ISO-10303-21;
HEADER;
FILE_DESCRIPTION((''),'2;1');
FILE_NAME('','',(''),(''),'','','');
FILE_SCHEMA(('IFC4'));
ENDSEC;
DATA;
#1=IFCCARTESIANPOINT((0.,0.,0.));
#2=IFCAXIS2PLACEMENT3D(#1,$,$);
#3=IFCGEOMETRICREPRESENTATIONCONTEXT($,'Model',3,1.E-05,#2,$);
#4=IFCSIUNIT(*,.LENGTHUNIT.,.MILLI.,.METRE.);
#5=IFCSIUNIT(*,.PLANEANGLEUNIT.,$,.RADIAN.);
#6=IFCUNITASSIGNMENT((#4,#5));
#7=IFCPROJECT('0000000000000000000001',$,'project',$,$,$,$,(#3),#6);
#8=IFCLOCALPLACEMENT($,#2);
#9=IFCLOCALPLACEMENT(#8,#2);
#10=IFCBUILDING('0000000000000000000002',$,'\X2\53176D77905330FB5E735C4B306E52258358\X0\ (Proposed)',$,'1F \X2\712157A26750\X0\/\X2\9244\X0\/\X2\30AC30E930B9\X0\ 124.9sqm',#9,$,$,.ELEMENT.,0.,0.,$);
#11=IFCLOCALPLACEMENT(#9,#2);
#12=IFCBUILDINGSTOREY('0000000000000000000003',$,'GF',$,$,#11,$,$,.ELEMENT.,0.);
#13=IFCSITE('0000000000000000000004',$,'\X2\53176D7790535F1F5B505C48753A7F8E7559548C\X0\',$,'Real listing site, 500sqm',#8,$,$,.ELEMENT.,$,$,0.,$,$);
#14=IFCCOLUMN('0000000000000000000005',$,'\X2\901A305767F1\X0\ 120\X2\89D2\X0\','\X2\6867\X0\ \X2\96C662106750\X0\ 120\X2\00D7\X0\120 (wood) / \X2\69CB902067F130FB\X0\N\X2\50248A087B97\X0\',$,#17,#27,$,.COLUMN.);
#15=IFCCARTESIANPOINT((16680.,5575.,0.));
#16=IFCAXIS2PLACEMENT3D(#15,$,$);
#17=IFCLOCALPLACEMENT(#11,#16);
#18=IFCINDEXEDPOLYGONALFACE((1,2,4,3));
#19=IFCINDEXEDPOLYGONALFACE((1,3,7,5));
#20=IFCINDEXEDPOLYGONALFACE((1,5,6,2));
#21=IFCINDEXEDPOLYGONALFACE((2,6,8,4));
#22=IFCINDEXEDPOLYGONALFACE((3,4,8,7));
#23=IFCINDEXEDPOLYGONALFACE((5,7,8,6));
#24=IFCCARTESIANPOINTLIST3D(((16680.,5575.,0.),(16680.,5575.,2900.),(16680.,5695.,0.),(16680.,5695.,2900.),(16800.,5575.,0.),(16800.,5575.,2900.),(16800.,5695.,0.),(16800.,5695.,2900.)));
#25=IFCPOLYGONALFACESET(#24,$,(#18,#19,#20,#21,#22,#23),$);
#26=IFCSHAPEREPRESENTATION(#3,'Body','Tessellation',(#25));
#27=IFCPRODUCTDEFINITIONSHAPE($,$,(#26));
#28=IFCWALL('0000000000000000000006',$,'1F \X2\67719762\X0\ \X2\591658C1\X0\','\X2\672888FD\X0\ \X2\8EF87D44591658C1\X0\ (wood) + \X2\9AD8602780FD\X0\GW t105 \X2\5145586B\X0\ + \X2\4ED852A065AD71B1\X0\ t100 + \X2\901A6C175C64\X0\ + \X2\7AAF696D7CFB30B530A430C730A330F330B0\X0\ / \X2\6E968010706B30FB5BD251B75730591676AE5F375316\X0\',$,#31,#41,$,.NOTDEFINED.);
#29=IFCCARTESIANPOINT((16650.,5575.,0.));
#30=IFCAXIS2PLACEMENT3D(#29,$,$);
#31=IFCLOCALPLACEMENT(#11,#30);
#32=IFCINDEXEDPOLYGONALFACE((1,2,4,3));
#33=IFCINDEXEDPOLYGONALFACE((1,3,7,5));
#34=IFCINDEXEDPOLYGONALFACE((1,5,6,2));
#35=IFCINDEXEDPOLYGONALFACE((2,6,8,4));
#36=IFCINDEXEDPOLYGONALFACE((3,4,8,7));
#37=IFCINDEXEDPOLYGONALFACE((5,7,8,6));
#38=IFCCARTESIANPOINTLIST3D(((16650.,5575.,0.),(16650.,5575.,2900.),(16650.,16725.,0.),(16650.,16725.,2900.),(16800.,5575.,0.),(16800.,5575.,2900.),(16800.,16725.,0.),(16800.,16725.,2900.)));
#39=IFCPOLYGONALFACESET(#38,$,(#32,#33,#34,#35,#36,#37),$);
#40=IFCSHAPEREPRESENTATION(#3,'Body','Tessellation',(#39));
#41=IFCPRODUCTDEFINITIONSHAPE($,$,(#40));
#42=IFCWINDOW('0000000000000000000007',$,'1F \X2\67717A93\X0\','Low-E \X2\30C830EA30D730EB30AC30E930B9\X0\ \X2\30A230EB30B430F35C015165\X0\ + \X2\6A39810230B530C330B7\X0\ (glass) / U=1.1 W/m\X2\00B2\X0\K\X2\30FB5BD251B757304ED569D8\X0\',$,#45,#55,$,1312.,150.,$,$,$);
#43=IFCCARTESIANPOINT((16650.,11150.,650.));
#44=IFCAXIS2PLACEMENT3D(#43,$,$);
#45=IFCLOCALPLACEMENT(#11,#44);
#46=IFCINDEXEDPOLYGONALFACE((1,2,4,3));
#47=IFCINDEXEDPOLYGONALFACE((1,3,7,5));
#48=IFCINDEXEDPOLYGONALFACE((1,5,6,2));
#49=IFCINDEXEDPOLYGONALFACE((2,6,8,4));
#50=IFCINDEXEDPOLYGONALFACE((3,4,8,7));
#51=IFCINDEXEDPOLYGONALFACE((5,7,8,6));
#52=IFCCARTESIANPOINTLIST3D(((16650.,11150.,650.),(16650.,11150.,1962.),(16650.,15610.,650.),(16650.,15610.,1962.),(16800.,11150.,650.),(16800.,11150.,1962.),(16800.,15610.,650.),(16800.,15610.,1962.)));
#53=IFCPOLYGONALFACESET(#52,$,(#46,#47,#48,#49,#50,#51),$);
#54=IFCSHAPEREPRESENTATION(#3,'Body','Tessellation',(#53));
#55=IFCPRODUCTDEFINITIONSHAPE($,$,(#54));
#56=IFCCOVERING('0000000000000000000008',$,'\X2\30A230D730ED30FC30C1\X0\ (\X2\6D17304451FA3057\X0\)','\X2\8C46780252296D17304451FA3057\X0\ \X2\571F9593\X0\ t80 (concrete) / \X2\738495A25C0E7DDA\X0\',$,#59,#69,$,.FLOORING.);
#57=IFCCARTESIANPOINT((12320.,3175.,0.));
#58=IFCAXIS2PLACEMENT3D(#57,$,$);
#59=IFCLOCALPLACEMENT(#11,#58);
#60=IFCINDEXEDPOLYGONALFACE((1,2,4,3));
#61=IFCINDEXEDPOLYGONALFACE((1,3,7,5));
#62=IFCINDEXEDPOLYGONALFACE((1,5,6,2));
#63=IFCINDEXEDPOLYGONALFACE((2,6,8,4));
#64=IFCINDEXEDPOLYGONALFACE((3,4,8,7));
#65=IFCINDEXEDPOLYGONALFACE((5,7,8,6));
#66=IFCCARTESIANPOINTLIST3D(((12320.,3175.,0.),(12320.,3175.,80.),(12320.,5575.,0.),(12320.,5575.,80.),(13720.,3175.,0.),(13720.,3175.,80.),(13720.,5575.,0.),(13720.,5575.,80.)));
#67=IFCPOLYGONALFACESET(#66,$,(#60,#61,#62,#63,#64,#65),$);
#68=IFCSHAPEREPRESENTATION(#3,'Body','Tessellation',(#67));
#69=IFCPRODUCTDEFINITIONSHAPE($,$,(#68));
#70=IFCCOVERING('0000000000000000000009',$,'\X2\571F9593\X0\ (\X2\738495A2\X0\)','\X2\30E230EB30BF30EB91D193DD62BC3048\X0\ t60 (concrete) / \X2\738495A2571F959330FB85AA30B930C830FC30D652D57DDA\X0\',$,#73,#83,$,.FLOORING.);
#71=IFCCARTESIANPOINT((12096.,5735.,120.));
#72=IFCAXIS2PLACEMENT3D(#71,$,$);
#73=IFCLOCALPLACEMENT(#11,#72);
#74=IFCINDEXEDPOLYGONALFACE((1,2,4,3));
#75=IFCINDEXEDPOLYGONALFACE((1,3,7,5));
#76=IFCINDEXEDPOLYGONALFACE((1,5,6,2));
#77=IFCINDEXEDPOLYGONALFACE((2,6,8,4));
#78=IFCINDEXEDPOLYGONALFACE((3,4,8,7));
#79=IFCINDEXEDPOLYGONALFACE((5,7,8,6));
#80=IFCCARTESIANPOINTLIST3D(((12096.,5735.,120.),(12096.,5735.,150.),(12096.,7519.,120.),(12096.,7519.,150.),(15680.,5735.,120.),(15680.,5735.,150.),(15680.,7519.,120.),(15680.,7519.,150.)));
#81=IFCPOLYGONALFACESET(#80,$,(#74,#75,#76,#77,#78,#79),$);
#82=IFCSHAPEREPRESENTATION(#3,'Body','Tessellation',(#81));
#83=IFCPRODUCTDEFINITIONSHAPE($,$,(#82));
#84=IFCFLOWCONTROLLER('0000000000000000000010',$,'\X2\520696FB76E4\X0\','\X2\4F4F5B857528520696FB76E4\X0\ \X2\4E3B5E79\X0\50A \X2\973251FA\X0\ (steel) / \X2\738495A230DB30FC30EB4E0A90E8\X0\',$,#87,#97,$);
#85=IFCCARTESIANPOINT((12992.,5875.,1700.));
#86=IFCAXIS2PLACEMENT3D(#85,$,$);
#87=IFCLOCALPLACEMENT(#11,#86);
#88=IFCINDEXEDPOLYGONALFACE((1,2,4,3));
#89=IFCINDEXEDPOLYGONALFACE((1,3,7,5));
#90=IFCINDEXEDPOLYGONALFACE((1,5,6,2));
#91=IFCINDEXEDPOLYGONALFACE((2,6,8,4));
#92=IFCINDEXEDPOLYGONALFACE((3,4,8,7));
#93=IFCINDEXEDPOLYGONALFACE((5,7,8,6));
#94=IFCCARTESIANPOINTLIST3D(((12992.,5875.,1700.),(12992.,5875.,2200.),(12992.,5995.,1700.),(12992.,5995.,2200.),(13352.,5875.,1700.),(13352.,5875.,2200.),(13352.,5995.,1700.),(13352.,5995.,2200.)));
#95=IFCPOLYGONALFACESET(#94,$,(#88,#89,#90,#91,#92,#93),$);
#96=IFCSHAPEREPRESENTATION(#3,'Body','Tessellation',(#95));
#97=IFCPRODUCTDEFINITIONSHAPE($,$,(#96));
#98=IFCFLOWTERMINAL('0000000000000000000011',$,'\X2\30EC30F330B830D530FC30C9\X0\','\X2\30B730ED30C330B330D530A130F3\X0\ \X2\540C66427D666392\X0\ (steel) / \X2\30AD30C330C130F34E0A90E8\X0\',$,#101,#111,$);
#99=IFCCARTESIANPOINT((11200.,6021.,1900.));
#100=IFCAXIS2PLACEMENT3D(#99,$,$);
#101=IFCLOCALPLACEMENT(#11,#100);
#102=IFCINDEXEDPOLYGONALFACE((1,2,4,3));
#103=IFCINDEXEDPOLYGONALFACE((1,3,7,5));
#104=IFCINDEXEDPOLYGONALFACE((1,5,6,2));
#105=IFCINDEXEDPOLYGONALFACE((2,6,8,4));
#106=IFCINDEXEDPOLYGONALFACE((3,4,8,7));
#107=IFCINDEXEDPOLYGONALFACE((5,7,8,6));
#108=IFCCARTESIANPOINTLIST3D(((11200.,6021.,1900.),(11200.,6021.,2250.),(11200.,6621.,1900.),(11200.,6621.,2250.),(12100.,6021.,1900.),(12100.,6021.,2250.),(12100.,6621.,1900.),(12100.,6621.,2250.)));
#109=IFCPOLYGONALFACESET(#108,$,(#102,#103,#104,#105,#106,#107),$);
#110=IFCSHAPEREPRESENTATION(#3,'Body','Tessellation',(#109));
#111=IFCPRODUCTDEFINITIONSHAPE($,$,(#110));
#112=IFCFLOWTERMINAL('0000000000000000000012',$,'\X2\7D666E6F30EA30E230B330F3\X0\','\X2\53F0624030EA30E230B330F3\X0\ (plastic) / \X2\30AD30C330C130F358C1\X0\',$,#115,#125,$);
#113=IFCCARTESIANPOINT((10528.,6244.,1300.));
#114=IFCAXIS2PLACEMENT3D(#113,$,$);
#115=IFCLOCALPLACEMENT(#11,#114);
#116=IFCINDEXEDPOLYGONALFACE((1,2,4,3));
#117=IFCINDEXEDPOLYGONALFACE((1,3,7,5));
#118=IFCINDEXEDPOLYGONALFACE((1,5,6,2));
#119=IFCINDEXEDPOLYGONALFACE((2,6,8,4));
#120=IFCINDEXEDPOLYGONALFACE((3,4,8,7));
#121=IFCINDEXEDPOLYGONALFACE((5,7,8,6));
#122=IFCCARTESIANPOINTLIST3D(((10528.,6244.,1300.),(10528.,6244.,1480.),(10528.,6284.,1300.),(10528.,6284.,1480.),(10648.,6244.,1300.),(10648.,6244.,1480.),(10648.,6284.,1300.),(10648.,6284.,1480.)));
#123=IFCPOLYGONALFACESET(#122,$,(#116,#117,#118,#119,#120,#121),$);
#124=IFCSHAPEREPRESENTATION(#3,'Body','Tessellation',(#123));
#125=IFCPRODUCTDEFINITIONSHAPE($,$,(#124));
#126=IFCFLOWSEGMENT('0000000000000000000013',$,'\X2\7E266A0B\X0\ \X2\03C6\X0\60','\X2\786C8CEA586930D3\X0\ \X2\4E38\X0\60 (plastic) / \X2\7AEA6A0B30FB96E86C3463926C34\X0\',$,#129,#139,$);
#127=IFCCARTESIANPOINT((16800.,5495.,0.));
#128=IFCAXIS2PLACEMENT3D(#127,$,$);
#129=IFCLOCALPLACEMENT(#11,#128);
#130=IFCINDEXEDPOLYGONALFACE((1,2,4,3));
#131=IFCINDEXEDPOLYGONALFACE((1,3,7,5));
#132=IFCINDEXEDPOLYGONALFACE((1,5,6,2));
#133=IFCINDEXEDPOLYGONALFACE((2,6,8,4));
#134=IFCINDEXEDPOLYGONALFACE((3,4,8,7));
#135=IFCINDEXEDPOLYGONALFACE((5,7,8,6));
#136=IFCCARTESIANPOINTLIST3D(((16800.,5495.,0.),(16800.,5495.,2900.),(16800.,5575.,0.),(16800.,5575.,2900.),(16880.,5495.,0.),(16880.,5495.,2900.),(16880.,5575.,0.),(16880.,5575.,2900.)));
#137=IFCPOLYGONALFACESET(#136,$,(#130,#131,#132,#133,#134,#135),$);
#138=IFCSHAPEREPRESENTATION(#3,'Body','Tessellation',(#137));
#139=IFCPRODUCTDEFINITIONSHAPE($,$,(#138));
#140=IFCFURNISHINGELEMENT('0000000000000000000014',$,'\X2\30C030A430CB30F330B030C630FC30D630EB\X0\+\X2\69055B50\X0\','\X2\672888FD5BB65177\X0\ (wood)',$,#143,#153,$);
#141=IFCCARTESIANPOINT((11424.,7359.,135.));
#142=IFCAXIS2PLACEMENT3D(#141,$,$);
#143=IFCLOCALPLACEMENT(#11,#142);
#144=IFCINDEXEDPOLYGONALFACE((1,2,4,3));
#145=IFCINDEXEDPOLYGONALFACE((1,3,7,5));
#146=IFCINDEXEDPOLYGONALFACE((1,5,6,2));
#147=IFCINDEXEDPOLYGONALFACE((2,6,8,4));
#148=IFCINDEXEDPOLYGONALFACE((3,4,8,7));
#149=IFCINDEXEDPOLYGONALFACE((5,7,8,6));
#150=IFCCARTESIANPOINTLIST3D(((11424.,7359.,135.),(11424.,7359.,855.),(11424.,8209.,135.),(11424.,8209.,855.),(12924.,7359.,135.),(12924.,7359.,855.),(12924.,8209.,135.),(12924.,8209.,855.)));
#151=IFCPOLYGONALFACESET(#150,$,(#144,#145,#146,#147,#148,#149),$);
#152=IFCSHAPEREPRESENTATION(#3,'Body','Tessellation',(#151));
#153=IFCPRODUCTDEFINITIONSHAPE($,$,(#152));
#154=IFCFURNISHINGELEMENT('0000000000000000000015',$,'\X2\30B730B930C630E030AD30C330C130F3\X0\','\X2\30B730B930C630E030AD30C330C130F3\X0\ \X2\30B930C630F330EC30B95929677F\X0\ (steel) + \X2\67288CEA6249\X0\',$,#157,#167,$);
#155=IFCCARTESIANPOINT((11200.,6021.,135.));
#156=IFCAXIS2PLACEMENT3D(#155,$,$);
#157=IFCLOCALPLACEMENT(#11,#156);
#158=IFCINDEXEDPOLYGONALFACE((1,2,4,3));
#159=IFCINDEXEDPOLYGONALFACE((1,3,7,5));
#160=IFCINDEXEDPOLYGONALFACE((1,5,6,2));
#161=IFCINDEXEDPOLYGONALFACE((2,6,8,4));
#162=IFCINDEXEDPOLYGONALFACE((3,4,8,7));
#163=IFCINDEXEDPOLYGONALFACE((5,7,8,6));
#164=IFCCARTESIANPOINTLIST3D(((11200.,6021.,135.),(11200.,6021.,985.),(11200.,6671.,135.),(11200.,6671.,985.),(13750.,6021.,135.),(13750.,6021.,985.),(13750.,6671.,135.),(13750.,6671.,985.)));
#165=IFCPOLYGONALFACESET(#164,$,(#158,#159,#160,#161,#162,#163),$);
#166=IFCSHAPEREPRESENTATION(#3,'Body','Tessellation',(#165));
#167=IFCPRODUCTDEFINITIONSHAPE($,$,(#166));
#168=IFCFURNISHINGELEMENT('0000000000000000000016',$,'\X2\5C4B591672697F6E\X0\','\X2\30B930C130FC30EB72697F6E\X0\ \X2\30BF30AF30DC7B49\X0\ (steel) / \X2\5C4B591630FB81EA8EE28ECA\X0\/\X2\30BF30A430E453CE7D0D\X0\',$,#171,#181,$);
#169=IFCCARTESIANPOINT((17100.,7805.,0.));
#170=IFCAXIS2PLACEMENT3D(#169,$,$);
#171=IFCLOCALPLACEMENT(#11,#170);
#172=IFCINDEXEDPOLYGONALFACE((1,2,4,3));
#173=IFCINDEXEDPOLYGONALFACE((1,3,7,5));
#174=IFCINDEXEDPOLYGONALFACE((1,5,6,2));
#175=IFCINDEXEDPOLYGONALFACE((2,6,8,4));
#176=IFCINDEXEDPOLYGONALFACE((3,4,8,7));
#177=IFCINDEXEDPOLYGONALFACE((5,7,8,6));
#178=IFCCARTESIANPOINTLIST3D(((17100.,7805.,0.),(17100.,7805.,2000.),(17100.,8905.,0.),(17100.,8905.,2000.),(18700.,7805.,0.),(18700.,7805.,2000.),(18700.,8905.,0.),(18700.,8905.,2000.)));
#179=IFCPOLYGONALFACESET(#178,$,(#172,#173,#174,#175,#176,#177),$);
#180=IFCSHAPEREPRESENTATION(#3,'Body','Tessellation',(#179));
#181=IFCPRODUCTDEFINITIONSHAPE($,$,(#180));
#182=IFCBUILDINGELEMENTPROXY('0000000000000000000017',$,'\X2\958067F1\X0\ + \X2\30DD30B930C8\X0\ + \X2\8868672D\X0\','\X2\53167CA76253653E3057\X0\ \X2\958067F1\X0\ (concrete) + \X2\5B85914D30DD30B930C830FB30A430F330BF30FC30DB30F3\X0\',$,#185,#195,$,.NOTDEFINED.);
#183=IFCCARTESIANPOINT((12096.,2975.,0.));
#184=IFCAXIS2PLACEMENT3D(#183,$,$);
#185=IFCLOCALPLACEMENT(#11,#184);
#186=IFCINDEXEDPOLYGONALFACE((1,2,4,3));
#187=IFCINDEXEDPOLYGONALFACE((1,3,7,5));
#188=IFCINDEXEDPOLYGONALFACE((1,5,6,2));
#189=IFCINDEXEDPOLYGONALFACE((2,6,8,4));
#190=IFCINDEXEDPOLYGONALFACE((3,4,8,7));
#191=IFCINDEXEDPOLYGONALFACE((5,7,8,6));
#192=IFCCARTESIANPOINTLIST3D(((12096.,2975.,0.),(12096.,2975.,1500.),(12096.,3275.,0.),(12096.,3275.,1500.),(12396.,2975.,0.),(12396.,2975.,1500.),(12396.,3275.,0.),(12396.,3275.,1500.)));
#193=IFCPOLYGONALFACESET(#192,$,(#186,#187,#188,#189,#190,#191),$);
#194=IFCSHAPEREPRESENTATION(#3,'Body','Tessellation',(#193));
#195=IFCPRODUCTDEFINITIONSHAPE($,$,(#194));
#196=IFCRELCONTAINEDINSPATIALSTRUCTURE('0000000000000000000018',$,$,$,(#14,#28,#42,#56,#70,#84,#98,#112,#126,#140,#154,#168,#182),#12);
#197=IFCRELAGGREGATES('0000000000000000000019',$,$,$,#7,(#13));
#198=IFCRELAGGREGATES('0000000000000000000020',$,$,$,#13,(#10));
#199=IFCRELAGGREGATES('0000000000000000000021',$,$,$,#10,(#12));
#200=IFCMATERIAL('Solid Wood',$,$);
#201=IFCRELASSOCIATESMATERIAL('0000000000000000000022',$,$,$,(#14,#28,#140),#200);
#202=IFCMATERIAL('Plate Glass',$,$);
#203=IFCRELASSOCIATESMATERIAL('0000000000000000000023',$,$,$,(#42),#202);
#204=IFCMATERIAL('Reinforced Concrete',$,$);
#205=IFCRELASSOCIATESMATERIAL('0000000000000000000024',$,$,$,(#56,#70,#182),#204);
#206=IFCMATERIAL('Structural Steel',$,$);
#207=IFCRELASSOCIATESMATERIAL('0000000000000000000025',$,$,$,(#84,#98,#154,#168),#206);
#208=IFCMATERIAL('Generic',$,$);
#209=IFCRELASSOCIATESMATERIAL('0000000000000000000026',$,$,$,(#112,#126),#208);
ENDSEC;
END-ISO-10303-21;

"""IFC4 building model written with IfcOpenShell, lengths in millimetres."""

from ifc_helpers import new_model, si_unit, frame, frame_2d, origin, place, context, project, spatial, rectangle, extrude, material, element, fill, save


model = new_model("IFC4")

# Units and contexts
model_context = context("Model", 3, precision=1e-05, world=origin())
ifc_project = project(units=[si_unit("LENGTHUNIT", "METRE", prefix="MILLI"), si_unit("PLANEANGLEUNIT", "RADIAN")], contexts=[model_context])

# Site, building, storey
site_placement = place(None, origin())
site = spatial("IfcSite", under=ifc_project, at=site_placement, Name="北海道弟子屈町美留和", ObjectType="Real listing site, 500sqm", CompositionType="ELEMENT", RefElevation=0.0)
building_placement = place(site_placement, origin())
building = spatial("IfcBuilding", under=site, at=building_placement, Name="北海道・平屋の別荘 (Proposed)", ObjectType="1F 無垢材/鉄/ガラス 124.9sqm", CompositionType="ELEMENT", ElevationOfRefHeight=0.0, ElevationOfTerrain=0.0)
storey_placement = place(building_placement, origin())
storey = spatial("IfcBuildingStorey", under=building, at=storey_placement, Name="GF", CompositionType="ELEMENT", Elevation=0.0)

# Column
ifc_material_1 = material(Name="Solid Wood")
column_1_placement = place(storey_placement, frame((16680.0, 5575.0, 0.0)))
element("IfcColumn", 1, at=column_1_placement, inside=storey, material=ifc_material_1, Name="通し柱 120角", Description="桧 集成材 120×120 (wood) / 構造柱・N値計算", PredefinedType="COLUMN", context=model_context, shape_type="SweptSolid", body=[
    extrude(rectangle(XDim=120.0, YDim=120.0, at=frame_2d((60.0, 60.0))), frame((16680.0, 5575.0, 0.0)), (0.0, 0.0, 1.0), 2900.0),
])

# Wall, opening, window
wall_1_placement = place(storey_placement, frame((16650.0, 5575.0, 0.0)))
wall_1 = element("IfcWall", 2, at=wall_1_placement, inside=storey, material=ifc_material_1, Name="1F 東面 外壁", Description="木製 軸組外壁 (wood) + 高性能GW t105 充填 + 付加断熱 t100 + 通気層 + 窯業系サイディング / 準耐火・寒冷地外皮強化", PredefinedType="NOTDEFINED", context=model_context, shape_type="SweptSolid", body=[
    extrude(rectangle(XDim=150.0, YDim=11150.0, at=frame_2d((75.0, 5575.0))), frame((16650.0, 5575.0, 0.0)), (0.0, 0.0, 1.0), 2900.0),
])
opening_placement = place(storey_placement, frame((16650.0, 11150.0, 650.0)))
opening = element("IfcOpeningElement", 3, at=opening_placement, cuts=wall_1, PredefinedType="NOTDEFINED", context=model_context, shape_type="SweptSolid", body=[
    extrude(rectangle(XDim=150.0, YDim=4460.0, at=frame_2d((75.0, 2230.0))), frame((16650.0, 11150.0, 650.0)), (0.0, 0.0, 1.0), 1312.0),
])
ifc_material_2 = material(Name="Plate Glass")
window_placement = place(storey_placement, frame((16650.0, 11150.0, 650.0)))
window = element("IfcWindow", 4, at=window_placement, inside=storey, material=ifc_material_2, Name="1F 東窓", Description="Low-E トリプルガラス アルゴン封入 + 樹脂サッシ (glass) / U=1.1 W/m²K・寒冷地仕様", OverallHeight=1312.0, OverallWidth=150.0, context=model_context, shape_type="SweptSolid", body=[
    extrude(rectangle(XDim=150.0, YDim=4460.0, at=frame_2d((75.0, 2230.0))), frame((16650.0, 11150.0, 650.0)), (0.0, 0.0, 1.0), 1312.0),
])
fill(opening, window)

# Coverings
ifc_material_3 = material(Name="Reinforced Concrete")
covering_1_placement = place(storey_placement, frame((12320.0, 3175.0, 0.0)))
element("IfcCovering", 5, at=covering_1_placement, inside=storey, material=ifc_material_3, Name="アプローチ (洗い出し)", Description="豆砂利洗い出し 土間 t80 (concrete) / 玄関導線", PredefinedType="FLOORING", context=model_context, shape_type="SweptSolid", body=[
    extrude(rectangle(XDim=1400.0, YDim=2400.0, at=frame_2d((700.0, 1200.0))), frame((12320.0, 3175.0, 0.0)), (0.0, 0.0, 1.0), 80.0),
])
covering_2_placement = place(storey_placement, frame((12096.0, 5735.0, 120.0)))
element("IfcCovering", 6, at=covering_2_placement, inside=storey, material=ifc_material_3, Name="土間 (玄関)", Description="モルタル金鏝押え t60 (concrete) / 玄関土間・薪ストーブ動線", PredefinedType="FLOORING", context=model_context, shape_type="SweptSolid", body=[
    extrude(rectangle(XDim=3584.0, YDim=1784.0, at=frame_2d((1792.0, 892.0))), frame((12096.0, 5735.0, 120.0)), (0.0, 0.0, 1.0), 30.0),
])

# Flow controller
ifc_material_4 = material(Name="Structural Steel")
flow_controller_placement = place(storey_placement, frame((12992.0, 5875.0, 1700.0)))
element("IfcFlowController", 7, at=flow_controller_placement, inside=storey, material=ifc_material_4, Name="分電盤", Description="住宅用分電盤 主幹50A 露出 (steel) / 玄関ホール上部", context=model_context, shape_type="SweptSolid", body=[
    extrude(rectangle(XDim=360.0, YDim=120.0, at=frame_2d((180.0, 60.0))), frame((12992.0, 5875.0, 1700.0)), (0.0, 0.0, 1.0), 500.0),
])

# Flow terminals
flow_terminal_1_placement = place(storey_placement, frame((11200.0, 6021.0, 1900.0)))
element("IfcFlowTerminal", 8, at=flow_terminal_1_placement, inside=storey, material=ifc_material_4, Name="レンジフード", Description="シロッコファン 同時給排 (steel) / キッチン上部", context=model_context, shape_type="SweptSolid", body=[
    extrude(rectangle(XDim=900.0, YDim=600.0, at=frame_2d((450.0, 300.0))), frame((11200.0, 6021.0, 1900.0)), (0.0, 0.0, 1.0), 350.0),
])
ifc_material_5 = material(Name="Generic")
flow_terminal_2_placement = place(storey_placement, frame((10528.0, 6244.0, 1300.0)))
element("IfcFlowTerminal", 9, at=flow_terminal_2_placement, inside=storey, material=ifc_material_5, Name="給湯リモコン", Description="台所リモコン (plastic) / キッチン壁", context=model_context, shape_type="SweptSolid", body=[
    extrude(rectangle(XDim=120.0, YDim=40.0, at=frame_2d((60.0, 20.0))), frame((10528.0, 6244.0, 1300.0)), (0.0, 0.0, 1.0), 180.0),
])

# Flow segment
flow_segment_placement = place(storey_placement, frame((16800.0, 5495.0, 0.0)))
element("IfcFlowSegment", 10, at=flow_segment_placement, inside=storey, material=ifc_material_5, Name="縦樋 φ60", Description="硬質塩ビ 丸60 (plastic) / 竪樋・雨水排水", context=model_context, shape_type="SweptSolid", body=[
    extrude(rectangle(XDim=80.0, YDim=80.0, at=frame_2d((40.0, 40.0))), frame((16800.0, 5495.0, 0.0)), (0.0, 0.0, 1.0), 2900.0),
])

# Furnishing elements
furnishing_1_placement = place(storey_placement, frame((11424.0, 7359.0, 135.0)))
element("IfcFurnishingElement", 11, at=furnishing_1_placement, inside=storey, material=ifc_material_1, Name="ダイニングテーブル+椅子", Description="木製家具 (wood)", context=model_context, shape_type="SweptSolid", body=[
    extrude(rectangle(XDim=1500.0, YDim=850.0, at=frame_2d((750.0, 425.0))), frame((11424.0, 7359.0, 135.0)), (0.0, 0.0, 1.0), 720.0),
])
furnishing_2_placement = place(storey_placement, frame((11200.0, 6021.0, 135.0)))
element("IfcFurnishingElement", 12, at=furnishing_2_placement, inside=storey, material=ifc_material_4, Name="システムキッチン", Description="システムキッチン ステンレス天板 (steel) + 木質扉", context=model_context, shape_type="SweptSolid", body=[
    extrude(rectangle(XDim=2550.0, YDim=650.0, at=frame_2d((1275.0, 325.0))), frame((11200.0, 6021.0, 135.0)), (0.0, 0.0, 1.0), 850.0),
])
furnishing_3_placement = place(storey_placement, frame((17100.0, 7805.0, 0.0)))
element("IfcFurnishingElement", 13, at=furnishing_3_placement, inside=storey, material=ifc_material_4, Name="屋外物置", Description="スチール物置 タクボ等 (steel) / 屋外・自転車/タイヤ収納", context=model_context, shape_type="SweptSolid", body=[
    extrude(rectangle(XDim=1600.0, YDim=1100.0, at=frame_2d((800.0, 550.0))), frame((17100.0, 7805.0, 0.0)), (0.0, 0.0, 1.0), 2000.0),
])

# Building element proxy
proxy_placement = place(storey_placement, frame((12096.0, 2975.0, 0.0)))
element("IfcBuildingElementProxy", 14, at=proxy_placement, inside=storey, material=ifc_material_3, Name="門柱 + ポスト + 表札", Description="化粧打放し 門柱 (concrete) + 宅配ポスト・インターホン", PredefinedType="NOTDEFINED", context=model_context, shape_type="SweptSolid", body=[
    extrude(rectangle(XDim=300.0, YDim=300.0, at=frame_2d((150.0, 150.0))), frame((12096.0, 2975.0, 0.0)), (0.0, 0.0, 1.0), 1500.0),
])

save(model, "model.ifc")
